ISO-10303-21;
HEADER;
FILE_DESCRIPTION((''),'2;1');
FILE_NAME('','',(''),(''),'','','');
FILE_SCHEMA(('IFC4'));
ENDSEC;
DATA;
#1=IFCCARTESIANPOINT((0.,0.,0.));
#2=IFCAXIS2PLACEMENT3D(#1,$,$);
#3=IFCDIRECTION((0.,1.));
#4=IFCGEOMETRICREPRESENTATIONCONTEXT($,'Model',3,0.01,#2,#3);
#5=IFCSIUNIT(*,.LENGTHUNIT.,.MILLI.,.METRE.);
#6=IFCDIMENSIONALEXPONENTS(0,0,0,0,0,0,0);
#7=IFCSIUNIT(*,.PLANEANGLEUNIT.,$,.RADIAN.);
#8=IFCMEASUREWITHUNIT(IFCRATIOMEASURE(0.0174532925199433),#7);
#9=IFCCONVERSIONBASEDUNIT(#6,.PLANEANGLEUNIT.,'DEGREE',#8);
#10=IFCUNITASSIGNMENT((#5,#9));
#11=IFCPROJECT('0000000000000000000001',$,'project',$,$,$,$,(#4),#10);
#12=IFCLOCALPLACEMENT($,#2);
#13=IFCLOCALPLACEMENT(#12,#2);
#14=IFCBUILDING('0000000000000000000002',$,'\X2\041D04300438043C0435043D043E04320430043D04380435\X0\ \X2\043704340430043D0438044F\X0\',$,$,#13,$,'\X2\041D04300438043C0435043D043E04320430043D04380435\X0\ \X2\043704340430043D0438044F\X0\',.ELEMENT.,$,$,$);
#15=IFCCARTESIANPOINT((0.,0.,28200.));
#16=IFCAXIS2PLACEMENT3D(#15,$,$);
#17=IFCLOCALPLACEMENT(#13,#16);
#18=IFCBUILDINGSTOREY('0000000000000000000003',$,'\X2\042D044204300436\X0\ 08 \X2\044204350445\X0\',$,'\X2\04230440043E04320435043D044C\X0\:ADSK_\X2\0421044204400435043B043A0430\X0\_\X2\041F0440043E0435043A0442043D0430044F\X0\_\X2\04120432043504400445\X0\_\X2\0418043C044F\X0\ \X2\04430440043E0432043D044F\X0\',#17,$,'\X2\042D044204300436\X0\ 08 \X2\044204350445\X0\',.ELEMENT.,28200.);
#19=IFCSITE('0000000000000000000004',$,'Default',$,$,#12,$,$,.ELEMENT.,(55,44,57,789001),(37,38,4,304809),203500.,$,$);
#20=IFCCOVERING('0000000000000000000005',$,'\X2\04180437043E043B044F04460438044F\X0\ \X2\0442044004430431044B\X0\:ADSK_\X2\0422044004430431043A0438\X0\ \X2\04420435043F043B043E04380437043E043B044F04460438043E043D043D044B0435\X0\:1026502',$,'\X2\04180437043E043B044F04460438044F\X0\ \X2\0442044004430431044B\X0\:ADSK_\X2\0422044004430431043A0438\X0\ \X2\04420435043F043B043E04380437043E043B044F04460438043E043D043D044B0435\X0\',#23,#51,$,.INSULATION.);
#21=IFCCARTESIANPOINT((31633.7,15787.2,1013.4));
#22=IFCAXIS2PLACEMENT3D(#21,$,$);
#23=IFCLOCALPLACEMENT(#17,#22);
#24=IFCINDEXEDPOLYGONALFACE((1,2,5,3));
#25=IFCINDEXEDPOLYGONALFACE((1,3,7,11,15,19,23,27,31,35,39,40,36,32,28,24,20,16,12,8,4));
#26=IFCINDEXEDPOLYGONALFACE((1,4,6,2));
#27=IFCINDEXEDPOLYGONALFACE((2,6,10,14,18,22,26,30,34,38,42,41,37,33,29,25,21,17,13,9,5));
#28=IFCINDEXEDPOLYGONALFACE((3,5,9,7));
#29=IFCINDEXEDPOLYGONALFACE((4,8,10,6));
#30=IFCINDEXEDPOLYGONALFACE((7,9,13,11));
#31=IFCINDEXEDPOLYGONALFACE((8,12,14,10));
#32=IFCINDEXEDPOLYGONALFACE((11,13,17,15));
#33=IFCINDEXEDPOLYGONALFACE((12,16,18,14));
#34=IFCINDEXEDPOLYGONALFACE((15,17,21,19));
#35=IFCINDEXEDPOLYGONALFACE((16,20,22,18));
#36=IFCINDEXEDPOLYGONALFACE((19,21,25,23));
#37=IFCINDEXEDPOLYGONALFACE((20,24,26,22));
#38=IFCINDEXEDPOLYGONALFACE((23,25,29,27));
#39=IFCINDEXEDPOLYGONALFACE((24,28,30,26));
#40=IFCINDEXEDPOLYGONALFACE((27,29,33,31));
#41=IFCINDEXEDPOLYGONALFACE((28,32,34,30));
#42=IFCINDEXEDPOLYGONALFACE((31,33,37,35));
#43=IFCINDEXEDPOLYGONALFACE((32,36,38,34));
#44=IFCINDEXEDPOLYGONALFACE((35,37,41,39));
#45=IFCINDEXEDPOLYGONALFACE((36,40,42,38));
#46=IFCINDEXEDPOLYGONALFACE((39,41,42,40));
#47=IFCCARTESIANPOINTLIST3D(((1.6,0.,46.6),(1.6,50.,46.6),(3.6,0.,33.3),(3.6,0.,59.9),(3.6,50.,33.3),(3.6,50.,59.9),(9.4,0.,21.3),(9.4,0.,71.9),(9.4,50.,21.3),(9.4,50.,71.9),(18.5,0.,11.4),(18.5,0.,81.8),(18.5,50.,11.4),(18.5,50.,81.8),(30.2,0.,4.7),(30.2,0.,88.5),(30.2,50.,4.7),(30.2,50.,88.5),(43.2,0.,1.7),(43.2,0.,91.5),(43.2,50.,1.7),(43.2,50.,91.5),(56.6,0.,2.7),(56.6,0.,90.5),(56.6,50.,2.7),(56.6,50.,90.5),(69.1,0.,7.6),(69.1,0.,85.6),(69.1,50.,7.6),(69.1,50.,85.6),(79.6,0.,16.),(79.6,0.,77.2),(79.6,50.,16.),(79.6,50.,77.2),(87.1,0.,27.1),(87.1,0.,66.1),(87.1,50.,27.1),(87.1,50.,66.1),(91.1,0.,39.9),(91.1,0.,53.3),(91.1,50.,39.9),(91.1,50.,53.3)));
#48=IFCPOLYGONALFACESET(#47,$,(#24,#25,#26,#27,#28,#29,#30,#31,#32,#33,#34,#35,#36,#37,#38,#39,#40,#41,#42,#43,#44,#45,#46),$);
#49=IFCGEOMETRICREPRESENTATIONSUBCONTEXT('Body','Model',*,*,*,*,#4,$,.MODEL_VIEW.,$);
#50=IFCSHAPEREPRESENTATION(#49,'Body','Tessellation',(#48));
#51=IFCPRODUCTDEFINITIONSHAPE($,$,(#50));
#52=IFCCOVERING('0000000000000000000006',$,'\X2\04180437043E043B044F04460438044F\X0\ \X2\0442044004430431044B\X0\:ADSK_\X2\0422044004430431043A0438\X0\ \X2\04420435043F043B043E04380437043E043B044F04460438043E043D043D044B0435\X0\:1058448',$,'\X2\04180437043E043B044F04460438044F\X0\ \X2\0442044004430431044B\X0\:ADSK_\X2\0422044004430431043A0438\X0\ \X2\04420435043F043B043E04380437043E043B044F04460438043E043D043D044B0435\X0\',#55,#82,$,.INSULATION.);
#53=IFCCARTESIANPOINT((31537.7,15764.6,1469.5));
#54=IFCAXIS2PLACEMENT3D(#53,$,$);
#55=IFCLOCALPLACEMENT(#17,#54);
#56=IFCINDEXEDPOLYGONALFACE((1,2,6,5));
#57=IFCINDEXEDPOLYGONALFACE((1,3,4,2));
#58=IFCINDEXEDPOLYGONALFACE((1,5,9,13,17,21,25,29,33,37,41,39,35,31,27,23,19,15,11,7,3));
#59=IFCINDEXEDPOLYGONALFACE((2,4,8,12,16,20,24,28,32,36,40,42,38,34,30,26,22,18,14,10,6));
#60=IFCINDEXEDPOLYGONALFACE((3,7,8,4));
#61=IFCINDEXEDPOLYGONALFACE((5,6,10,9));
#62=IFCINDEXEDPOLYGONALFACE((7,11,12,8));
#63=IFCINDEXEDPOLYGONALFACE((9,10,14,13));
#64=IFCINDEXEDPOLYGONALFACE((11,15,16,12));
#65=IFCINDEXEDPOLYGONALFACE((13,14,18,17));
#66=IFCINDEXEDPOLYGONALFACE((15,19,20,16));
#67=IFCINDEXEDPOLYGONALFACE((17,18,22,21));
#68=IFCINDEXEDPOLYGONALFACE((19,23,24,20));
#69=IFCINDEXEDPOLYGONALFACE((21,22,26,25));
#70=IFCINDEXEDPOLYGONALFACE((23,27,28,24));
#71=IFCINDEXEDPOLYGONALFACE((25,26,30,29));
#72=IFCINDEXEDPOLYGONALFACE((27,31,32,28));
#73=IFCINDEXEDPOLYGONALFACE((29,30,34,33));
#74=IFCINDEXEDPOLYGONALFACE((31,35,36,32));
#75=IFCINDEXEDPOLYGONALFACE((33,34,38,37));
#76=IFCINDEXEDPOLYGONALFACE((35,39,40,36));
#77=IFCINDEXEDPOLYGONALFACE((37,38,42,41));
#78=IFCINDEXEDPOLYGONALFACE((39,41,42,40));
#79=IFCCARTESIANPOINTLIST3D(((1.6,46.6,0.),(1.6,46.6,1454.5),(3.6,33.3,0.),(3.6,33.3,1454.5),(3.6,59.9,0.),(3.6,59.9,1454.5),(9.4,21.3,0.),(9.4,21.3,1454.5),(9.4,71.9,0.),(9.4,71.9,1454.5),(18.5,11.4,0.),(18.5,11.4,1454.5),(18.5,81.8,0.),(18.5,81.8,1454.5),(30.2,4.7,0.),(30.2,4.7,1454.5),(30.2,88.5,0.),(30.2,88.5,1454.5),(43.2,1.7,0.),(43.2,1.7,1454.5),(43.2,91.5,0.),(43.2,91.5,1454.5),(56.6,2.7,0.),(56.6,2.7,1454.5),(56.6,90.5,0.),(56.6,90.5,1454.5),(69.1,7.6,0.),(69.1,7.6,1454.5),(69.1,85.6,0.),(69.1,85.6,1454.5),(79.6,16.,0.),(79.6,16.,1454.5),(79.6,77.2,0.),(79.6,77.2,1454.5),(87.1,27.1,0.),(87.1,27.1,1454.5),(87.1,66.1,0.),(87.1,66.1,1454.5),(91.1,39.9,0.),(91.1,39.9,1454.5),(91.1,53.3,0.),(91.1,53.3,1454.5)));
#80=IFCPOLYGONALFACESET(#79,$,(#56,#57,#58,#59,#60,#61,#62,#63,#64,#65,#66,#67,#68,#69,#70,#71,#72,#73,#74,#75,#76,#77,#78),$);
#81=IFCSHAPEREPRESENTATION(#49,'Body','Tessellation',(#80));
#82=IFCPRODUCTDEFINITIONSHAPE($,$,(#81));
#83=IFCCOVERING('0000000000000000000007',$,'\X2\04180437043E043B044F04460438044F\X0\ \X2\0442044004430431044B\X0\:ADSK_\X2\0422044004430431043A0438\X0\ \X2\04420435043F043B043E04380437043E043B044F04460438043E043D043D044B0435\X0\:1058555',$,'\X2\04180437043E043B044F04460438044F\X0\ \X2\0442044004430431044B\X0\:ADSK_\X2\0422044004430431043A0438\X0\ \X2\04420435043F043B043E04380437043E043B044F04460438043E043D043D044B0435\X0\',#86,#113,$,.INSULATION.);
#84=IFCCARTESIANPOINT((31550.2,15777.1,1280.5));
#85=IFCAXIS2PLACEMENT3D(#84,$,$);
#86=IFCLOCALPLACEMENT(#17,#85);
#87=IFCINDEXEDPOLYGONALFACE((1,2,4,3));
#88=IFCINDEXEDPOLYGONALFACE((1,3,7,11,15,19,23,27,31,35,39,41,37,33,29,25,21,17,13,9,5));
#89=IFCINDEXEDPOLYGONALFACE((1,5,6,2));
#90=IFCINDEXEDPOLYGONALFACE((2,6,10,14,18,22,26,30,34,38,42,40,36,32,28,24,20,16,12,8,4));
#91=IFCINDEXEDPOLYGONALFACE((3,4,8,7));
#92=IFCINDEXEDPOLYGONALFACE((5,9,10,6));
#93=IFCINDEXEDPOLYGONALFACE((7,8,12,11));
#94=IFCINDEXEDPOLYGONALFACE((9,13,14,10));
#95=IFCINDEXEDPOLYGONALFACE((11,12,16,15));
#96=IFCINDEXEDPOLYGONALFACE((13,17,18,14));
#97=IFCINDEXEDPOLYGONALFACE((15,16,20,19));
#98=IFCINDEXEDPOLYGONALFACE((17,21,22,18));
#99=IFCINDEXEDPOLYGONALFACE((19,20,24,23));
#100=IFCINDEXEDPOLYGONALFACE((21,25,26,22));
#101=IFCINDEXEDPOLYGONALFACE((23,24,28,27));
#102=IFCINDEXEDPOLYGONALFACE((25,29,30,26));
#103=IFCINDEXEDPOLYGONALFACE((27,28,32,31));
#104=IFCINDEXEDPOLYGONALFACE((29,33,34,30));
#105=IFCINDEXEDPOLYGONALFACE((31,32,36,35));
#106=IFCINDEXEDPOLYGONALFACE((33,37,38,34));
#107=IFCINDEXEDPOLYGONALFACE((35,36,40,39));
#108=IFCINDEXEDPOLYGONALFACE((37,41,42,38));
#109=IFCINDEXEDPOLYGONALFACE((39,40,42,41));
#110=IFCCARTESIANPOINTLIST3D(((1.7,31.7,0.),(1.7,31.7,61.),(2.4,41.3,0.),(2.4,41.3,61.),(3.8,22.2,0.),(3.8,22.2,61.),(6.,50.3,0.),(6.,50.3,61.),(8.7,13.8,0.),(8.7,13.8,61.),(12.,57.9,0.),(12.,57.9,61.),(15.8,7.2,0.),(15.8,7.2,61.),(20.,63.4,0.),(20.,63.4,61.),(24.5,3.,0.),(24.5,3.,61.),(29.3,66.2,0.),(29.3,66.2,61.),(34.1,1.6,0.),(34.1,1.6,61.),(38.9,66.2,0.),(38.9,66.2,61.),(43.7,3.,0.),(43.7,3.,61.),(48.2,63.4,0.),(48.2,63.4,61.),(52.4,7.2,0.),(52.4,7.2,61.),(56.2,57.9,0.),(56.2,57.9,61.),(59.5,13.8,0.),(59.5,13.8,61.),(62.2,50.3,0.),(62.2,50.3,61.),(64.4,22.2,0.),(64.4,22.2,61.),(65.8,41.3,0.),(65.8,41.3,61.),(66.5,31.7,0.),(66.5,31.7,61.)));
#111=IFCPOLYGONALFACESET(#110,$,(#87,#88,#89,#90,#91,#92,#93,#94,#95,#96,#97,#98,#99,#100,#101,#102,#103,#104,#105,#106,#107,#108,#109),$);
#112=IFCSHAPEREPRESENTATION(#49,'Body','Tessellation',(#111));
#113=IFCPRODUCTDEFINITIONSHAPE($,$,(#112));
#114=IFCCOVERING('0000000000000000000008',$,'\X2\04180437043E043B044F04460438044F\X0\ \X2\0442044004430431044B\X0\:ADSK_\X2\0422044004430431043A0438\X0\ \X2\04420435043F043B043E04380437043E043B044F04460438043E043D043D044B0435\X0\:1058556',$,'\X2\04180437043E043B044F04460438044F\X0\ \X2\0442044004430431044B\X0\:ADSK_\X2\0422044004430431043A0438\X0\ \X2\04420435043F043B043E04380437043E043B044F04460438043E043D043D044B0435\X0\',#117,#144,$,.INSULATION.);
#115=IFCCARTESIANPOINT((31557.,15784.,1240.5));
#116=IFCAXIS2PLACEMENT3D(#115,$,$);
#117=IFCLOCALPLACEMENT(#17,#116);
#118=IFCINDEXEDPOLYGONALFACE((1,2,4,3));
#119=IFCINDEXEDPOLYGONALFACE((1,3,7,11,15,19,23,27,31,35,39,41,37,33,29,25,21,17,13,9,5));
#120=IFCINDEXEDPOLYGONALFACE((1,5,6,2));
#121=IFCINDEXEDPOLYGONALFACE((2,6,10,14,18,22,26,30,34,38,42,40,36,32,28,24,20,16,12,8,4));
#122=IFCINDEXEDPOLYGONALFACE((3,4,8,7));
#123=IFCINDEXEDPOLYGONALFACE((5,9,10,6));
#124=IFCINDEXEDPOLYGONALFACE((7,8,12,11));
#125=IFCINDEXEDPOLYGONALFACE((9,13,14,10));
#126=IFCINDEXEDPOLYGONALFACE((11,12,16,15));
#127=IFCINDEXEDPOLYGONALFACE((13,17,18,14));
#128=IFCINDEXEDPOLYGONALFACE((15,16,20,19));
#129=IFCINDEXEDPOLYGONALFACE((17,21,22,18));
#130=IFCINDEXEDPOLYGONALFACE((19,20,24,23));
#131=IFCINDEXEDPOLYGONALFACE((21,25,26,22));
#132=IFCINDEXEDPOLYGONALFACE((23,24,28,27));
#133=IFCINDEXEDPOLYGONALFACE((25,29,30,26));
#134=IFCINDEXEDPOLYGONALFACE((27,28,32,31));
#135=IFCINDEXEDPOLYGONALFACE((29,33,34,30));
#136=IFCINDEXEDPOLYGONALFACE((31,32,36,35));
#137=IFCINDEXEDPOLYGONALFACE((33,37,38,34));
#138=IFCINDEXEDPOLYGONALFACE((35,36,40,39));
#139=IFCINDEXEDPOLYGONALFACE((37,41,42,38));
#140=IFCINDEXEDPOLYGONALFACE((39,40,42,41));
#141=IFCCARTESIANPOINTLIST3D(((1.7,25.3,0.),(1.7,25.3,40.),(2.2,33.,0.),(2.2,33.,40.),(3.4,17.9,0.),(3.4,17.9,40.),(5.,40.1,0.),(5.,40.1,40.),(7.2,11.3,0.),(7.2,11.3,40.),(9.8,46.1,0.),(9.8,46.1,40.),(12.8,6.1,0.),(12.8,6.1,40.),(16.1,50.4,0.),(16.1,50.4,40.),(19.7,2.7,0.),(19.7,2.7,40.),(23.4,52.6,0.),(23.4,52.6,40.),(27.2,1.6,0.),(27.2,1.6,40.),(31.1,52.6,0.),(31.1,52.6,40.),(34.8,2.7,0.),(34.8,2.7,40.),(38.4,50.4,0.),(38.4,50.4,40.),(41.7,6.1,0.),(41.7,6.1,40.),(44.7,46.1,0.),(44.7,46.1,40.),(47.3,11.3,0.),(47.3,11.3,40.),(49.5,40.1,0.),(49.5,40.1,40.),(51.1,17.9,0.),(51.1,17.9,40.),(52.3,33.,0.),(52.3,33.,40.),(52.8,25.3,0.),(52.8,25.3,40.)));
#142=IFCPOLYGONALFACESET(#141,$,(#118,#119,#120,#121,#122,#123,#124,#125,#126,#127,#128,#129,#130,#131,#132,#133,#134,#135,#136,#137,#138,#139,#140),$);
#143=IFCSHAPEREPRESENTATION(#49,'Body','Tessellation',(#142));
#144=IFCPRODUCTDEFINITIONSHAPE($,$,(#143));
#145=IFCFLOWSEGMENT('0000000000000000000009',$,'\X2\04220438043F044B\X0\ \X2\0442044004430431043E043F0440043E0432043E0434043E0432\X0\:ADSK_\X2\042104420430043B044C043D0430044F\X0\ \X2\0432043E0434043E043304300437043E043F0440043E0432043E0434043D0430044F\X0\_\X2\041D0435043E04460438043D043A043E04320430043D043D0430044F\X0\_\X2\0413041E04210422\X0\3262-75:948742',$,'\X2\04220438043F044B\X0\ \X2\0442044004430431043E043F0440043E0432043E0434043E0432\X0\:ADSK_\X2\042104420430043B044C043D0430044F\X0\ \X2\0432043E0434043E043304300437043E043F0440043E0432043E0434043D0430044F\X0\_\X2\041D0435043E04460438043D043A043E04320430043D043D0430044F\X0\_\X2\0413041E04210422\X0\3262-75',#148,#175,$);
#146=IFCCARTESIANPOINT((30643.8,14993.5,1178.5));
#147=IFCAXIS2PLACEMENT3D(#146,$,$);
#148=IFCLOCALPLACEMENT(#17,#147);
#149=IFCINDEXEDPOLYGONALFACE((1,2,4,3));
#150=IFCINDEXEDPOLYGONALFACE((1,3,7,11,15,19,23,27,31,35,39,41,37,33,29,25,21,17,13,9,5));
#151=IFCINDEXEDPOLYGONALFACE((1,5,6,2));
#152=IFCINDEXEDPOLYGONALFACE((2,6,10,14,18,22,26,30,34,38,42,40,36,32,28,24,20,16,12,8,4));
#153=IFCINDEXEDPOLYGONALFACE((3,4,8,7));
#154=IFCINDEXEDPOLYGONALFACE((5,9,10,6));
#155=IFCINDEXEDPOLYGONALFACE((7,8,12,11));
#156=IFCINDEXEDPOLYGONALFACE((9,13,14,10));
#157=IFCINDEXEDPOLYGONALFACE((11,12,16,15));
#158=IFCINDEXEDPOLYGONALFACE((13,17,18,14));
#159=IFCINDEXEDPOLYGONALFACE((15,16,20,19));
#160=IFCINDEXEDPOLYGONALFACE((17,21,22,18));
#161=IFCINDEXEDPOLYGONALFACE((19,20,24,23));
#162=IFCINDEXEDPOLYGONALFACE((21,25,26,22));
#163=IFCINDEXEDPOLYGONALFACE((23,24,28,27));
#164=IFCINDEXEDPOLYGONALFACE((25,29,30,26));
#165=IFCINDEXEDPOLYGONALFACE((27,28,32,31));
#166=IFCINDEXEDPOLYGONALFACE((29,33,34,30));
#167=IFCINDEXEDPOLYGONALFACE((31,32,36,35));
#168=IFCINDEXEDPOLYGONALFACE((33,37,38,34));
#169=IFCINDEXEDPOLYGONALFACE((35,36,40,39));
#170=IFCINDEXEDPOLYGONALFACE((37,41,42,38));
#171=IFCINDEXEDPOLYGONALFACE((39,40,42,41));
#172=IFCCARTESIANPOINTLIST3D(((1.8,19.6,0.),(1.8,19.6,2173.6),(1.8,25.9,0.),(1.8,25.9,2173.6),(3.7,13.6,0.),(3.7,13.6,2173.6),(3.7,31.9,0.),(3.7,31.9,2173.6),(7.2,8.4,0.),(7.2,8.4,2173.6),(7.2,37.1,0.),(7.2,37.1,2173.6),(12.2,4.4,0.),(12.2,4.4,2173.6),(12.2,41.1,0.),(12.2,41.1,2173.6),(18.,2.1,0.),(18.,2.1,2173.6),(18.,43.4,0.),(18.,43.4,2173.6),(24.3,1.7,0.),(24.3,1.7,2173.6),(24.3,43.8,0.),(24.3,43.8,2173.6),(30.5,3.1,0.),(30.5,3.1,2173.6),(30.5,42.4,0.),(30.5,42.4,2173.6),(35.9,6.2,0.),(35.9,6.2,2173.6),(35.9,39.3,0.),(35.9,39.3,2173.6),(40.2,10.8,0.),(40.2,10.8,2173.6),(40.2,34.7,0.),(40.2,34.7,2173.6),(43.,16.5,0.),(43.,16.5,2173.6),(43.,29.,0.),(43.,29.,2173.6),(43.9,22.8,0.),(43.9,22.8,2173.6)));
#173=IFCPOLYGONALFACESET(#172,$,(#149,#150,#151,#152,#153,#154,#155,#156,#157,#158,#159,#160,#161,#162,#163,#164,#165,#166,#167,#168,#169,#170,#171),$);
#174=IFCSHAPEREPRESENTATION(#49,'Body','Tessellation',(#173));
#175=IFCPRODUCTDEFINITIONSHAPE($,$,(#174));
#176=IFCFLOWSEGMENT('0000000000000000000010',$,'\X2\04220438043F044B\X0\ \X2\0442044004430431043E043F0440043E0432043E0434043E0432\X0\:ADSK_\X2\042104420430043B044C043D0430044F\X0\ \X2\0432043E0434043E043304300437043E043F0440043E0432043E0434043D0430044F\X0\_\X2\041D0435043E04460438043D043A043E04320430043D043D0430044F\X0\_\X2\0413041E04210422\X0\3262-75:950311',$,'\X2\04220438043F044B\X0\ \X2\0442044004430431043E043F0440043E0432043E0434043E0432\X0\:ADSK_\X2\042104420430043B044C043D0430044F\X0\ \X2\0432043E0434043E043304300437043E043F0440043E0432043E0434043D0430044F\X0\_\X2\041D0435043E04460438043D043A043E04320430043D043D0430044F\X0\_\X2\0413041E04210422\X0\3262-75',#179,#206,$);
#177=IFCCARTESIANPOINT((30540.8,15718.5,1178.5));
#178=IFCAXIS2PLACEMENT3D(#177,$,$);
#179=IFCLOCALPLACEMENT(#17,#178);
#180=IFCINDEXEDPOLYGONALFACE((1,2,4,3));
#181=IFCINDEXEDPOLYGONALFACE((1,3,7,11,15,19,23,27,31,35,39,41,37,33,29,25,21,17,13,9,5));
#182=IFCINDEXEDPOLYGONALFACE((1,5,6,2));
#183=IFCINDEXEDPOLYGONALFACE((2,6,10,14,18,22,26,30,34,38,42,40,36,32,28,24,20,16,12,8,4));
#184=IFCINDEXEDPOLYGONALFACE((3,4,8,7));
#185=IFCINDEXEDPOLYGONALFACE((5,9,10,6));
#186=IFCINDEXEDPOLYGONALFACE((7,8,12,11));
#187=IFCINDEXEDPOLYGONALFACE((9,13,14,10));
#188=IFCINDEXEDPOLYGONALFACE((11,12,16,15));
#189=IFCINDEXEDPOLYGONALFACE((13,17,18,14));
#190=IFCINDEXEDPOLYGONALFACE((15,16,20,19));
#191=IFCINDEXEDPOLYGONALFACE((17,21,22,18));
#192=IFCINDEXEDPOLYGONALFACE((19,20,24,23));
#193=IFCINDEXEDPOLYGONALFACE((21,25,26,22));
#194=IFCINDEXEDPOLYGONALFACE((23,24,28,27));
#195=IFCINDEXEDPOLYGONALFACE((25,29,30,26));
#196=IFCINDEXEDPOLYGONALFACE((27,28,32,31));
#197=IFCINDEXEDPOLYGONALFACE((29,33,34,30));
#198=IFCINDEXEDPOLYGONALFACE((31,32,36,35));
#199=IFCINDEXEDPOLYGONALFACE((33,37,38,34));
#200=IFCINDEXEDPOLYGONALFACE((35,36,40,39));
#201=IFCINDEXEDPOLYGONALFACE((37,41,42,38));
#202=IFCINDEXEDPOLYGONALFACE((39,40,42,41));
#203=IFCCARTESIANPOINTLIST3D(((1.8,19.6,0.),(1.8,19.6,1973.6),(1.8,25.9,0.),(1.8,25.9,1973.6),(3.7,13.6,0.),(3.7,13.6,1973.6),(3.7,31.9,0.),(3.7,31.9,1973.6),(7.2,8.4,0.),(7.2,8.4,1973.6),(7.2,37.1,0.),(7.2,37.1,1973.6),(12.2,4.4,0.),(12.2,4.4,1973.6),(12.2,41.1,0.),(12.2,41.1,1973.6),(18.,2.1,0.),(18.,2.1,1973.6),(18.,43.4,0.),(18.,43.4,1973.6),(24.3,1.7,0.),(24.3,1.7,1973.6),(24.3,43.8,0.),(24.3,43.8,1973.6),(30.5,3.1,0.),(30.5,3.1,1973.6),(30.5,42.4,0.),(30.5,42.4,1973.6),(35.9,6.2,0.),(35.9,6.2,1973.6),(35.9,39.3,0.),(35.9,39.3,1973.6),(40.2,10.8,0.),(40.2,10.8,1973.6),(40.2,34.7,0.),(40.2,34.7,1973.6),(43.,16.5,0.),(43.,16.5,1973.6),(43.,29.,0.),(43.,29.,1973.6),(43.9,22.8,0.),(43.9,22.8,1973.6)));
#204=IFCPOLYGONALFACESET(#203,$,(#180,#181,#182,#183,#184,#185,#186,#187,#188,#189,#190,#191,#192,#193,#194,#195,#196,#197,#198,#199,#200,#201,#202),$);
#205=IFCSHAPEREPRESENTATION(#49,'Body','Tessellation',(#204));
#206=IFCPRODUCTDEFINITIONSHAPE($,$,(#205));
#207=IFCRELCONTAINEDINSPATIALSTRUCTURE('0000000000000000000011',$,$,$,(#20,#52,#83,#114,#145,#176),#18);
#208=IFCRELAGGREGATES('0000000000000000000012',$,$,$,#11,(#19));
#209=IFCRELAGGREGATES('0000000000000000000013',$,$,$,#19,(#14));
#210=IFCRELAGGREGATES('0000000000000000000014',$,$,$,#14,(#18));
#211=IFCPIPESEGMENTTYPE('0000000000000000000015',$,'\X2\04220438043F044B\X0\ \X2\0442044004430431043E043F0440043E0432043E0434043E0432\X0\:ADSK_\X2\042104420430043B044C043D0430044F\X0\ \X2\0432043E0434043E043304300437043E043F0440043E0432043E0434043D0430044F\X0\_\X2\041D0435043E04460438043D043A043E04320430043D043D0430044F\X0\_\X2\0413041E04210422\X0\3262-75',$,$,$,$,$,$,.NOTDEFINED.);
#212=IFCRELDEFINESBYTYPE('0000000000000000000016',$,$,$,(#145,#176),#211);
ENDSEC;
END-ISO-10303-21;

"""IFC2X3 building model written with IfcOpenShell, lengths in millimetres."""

from ifc_helpers import new_model, entity, si_unit, converted_unit, direction, frame, origin, origin_2d_with_axis, place, context, subcontext, project, spatial, circle, extrude, type_object, element, save


model = new_model("IFC2X3")

# Units and contexts
model_context = context("Model", 3, precision=0.01, world=origin(), true_north=direction((0.0, 1.0)))
body_context = subcontext(model_context, "Body", "Model", "MODEL_VIEW")
ifc_project = project(units=[si_unit("LENGTHUNIT", "METRE", prefix="MILLI"), converted_unit("PLANEANGLEUNIT", "DEGREE", entity("IfcRatioMeasure", 0.0174532925199433), si_unit("PLANEANGLEUNIT", "RADIAN"), dimensions=[0, 0, 0, 0, 0, 0, 0])], contexts=[model_context])

# Site, building, storey
site_placement = place(None, origin())
site = spatial("IfcSite", under=ifc_project, at=site_placement, Name="Default", CompositionType="ELEMENT", RefLatitude=(55, 44, 57, 789001), RefLongitude=(37, 38, 4, 304809), RefElevation=203500.0)
building_placement = place(site_placement, origin())
building = spatial("IfcBuilding", under=site, at=building_placement, Name="Наименование здания", LongName="Наименование здания", CompositionType="ELEMENT")
storey_placement = place(building_placement, frame((0.0, 0.0, 28200.0)))
storey = spatial("IfcBuildingStorey", under=building, at=storey_placement, Name="Этаж 08 тех", ObjectType="Уровень:ADSK_Стрелка_Проектная_Вверх_Имя уровня", LongName="Этаж 08 тех", CompositionType="ELEMENT", Elevation=28200.0)

# Coverings
covering_1_placement = place(storey_placement, frame((31633.7, 15787.2, 1013.4)))
element("IfcCovering", 1, at=covering_1_placement, inside=storey, Name="Изоляция трубы:ADSK_Трубки теплоизоляционные:1026502", ObjectType="Изоляция трубы:ADSK_Трубки теплоизоляционные", PredefinedType="INSULATION", context=body_context, shape_type="SweptSolid", body=[
    extrude(circle(Radius=45.0, at=origin_2d_with_axis()), frame((46.6, 0.0, 46.6), z_axis=(0.0, 1.0, 0.0), x_axis=(-1.0, 0.0, 0.0)), (0.0, 0.0, 1.0), 50.0),
])
covering_2_placement = place(storey_placement, frame((31537.7, 15764.6, 1469.5)))
element("IfcCovering", 2, at=covering_2_placement, inside=storey, Name="Изоляция трубы:ADSK_Трубки теплоизоляционные:1058448", ObjectType="Изоляция трубы:ADSK_Трубки теплоизоляционные", PredefinedType="INSULATION", context=body_context, shape_type="SweptSolid", body=[
    extrude(circle(Radius=45.0, at=origin_2d_with_axis()), frame((46.6, 46.6, 0.0), z_axis=(0.0, 0.0, 1.0), x_axis=(-1.0, 0.0, 0.0)), (0.0, 0.0, 1.0), 1454.5),
])
covering_3_placement = place(storey_placement, frame((31550.2, 15777.1, 1280.5)))
element("IfcCovering", 3, at=covering_3_placement, inside=storey, Name="Изоляция трубы:ADSK_Трубки теплоизоляционные:1058555", ObjectType="Изоляция трубы:ADSK_Трубки теплоизоляционные", PredefinedType="INSULATION", context=body_context, shape_type="SweptSolid", body=[
    extrude(circle(Radius=32.5, at=origin_2d_with_axis()), frame((34.1, 34.1, 0.0), z_axis=(0.0, 0.0, 1.0), x_axis=(0.0, -1.0, 0.0)), (0.0, 0.0, 1.0), 61.0),
])
covering_4_placement = place(storey_placement, frame((31557.0, 15784.0, 1240.5)))
element("IfcCovering", 4, at=covering_4_placement, inside=storey, Name="Изоляция трубы:ADSK_Трубки теплоизоляционные:1058556", ObjectType="Изоляция трубы:ADSK_Трубки теплоизоляционные", PredefinedType="INSULATION", context=body_context, shape_type="SweptSolid", body=[
    extrude(circle(Radius=25.6, at=origin_2d_with_axis()), frame((27.2, 27.2, 0.0), z_axis=(0.0, 0.0, 1.0), x_axis=(0.0, -1.0, 0.0)), (0.0, 0.0, 1.0), 40.0),
])

# Flow segments
pipe_segment_type = type_object("IfcPipeSegmentType", Name="Типы трубопроводов:ADSK_Стальная водогазопроводная_Неоцинкованная_ГОСТ3262-75", PredefinedType="NOTDEFINED")
flow_segment_1_placement = place(storey_placement, frame((30643.8, 14993.5, 1178.5)))
element("IfcFlowSegment", 5, at=flow_segment_1_placement, inside=storey, type_object=pipe_segment_type, Name="Типы трубопроводов:ADSK_Стальная водогазопроводная_Неоцинкованная_ГОСТ3262-75:948742", ObjectType="Типы трубопроводов:ADSK_Стальная водогазопроводная_Неоцинкованная_ГОСТ3262-75", context=body_context, shape_type="SweptSolid", body=[
    extrude(circle(Radius=21.1, at=origin_2d_with_axis()), frame((22.8, 22.8, 0.0)), (0.0, 0.0, 1.0), 2173.6),
])
flow_segment_2_placement = place(storey_placement, frame((30540.8, 15718.5, 1178.5)))
element("IfcFlowSegment", 6, at=flow_segment_2_placement, inside=storey, type_object=pipe_segment_type, Name="Типы трубопроводов:ADSK_Стальная водогазопроводная_Неоцинкованная_ГОСТ3262-75:950311", ObjectType="Типы трубопроводов:ADSK_Стальная водогазопроводная_Неоцинкованная_ГОСТ3262-75", context=body_context, shape_type="SweptSolid", body=[
    extrude(circle(Radius=21.1, at=origin_2d_with_axis()), frame((22.8, 22.8, 0.0)), (0.0, 0.0, 1.0), 1973.6),
])

save(model, "model.ifc")
